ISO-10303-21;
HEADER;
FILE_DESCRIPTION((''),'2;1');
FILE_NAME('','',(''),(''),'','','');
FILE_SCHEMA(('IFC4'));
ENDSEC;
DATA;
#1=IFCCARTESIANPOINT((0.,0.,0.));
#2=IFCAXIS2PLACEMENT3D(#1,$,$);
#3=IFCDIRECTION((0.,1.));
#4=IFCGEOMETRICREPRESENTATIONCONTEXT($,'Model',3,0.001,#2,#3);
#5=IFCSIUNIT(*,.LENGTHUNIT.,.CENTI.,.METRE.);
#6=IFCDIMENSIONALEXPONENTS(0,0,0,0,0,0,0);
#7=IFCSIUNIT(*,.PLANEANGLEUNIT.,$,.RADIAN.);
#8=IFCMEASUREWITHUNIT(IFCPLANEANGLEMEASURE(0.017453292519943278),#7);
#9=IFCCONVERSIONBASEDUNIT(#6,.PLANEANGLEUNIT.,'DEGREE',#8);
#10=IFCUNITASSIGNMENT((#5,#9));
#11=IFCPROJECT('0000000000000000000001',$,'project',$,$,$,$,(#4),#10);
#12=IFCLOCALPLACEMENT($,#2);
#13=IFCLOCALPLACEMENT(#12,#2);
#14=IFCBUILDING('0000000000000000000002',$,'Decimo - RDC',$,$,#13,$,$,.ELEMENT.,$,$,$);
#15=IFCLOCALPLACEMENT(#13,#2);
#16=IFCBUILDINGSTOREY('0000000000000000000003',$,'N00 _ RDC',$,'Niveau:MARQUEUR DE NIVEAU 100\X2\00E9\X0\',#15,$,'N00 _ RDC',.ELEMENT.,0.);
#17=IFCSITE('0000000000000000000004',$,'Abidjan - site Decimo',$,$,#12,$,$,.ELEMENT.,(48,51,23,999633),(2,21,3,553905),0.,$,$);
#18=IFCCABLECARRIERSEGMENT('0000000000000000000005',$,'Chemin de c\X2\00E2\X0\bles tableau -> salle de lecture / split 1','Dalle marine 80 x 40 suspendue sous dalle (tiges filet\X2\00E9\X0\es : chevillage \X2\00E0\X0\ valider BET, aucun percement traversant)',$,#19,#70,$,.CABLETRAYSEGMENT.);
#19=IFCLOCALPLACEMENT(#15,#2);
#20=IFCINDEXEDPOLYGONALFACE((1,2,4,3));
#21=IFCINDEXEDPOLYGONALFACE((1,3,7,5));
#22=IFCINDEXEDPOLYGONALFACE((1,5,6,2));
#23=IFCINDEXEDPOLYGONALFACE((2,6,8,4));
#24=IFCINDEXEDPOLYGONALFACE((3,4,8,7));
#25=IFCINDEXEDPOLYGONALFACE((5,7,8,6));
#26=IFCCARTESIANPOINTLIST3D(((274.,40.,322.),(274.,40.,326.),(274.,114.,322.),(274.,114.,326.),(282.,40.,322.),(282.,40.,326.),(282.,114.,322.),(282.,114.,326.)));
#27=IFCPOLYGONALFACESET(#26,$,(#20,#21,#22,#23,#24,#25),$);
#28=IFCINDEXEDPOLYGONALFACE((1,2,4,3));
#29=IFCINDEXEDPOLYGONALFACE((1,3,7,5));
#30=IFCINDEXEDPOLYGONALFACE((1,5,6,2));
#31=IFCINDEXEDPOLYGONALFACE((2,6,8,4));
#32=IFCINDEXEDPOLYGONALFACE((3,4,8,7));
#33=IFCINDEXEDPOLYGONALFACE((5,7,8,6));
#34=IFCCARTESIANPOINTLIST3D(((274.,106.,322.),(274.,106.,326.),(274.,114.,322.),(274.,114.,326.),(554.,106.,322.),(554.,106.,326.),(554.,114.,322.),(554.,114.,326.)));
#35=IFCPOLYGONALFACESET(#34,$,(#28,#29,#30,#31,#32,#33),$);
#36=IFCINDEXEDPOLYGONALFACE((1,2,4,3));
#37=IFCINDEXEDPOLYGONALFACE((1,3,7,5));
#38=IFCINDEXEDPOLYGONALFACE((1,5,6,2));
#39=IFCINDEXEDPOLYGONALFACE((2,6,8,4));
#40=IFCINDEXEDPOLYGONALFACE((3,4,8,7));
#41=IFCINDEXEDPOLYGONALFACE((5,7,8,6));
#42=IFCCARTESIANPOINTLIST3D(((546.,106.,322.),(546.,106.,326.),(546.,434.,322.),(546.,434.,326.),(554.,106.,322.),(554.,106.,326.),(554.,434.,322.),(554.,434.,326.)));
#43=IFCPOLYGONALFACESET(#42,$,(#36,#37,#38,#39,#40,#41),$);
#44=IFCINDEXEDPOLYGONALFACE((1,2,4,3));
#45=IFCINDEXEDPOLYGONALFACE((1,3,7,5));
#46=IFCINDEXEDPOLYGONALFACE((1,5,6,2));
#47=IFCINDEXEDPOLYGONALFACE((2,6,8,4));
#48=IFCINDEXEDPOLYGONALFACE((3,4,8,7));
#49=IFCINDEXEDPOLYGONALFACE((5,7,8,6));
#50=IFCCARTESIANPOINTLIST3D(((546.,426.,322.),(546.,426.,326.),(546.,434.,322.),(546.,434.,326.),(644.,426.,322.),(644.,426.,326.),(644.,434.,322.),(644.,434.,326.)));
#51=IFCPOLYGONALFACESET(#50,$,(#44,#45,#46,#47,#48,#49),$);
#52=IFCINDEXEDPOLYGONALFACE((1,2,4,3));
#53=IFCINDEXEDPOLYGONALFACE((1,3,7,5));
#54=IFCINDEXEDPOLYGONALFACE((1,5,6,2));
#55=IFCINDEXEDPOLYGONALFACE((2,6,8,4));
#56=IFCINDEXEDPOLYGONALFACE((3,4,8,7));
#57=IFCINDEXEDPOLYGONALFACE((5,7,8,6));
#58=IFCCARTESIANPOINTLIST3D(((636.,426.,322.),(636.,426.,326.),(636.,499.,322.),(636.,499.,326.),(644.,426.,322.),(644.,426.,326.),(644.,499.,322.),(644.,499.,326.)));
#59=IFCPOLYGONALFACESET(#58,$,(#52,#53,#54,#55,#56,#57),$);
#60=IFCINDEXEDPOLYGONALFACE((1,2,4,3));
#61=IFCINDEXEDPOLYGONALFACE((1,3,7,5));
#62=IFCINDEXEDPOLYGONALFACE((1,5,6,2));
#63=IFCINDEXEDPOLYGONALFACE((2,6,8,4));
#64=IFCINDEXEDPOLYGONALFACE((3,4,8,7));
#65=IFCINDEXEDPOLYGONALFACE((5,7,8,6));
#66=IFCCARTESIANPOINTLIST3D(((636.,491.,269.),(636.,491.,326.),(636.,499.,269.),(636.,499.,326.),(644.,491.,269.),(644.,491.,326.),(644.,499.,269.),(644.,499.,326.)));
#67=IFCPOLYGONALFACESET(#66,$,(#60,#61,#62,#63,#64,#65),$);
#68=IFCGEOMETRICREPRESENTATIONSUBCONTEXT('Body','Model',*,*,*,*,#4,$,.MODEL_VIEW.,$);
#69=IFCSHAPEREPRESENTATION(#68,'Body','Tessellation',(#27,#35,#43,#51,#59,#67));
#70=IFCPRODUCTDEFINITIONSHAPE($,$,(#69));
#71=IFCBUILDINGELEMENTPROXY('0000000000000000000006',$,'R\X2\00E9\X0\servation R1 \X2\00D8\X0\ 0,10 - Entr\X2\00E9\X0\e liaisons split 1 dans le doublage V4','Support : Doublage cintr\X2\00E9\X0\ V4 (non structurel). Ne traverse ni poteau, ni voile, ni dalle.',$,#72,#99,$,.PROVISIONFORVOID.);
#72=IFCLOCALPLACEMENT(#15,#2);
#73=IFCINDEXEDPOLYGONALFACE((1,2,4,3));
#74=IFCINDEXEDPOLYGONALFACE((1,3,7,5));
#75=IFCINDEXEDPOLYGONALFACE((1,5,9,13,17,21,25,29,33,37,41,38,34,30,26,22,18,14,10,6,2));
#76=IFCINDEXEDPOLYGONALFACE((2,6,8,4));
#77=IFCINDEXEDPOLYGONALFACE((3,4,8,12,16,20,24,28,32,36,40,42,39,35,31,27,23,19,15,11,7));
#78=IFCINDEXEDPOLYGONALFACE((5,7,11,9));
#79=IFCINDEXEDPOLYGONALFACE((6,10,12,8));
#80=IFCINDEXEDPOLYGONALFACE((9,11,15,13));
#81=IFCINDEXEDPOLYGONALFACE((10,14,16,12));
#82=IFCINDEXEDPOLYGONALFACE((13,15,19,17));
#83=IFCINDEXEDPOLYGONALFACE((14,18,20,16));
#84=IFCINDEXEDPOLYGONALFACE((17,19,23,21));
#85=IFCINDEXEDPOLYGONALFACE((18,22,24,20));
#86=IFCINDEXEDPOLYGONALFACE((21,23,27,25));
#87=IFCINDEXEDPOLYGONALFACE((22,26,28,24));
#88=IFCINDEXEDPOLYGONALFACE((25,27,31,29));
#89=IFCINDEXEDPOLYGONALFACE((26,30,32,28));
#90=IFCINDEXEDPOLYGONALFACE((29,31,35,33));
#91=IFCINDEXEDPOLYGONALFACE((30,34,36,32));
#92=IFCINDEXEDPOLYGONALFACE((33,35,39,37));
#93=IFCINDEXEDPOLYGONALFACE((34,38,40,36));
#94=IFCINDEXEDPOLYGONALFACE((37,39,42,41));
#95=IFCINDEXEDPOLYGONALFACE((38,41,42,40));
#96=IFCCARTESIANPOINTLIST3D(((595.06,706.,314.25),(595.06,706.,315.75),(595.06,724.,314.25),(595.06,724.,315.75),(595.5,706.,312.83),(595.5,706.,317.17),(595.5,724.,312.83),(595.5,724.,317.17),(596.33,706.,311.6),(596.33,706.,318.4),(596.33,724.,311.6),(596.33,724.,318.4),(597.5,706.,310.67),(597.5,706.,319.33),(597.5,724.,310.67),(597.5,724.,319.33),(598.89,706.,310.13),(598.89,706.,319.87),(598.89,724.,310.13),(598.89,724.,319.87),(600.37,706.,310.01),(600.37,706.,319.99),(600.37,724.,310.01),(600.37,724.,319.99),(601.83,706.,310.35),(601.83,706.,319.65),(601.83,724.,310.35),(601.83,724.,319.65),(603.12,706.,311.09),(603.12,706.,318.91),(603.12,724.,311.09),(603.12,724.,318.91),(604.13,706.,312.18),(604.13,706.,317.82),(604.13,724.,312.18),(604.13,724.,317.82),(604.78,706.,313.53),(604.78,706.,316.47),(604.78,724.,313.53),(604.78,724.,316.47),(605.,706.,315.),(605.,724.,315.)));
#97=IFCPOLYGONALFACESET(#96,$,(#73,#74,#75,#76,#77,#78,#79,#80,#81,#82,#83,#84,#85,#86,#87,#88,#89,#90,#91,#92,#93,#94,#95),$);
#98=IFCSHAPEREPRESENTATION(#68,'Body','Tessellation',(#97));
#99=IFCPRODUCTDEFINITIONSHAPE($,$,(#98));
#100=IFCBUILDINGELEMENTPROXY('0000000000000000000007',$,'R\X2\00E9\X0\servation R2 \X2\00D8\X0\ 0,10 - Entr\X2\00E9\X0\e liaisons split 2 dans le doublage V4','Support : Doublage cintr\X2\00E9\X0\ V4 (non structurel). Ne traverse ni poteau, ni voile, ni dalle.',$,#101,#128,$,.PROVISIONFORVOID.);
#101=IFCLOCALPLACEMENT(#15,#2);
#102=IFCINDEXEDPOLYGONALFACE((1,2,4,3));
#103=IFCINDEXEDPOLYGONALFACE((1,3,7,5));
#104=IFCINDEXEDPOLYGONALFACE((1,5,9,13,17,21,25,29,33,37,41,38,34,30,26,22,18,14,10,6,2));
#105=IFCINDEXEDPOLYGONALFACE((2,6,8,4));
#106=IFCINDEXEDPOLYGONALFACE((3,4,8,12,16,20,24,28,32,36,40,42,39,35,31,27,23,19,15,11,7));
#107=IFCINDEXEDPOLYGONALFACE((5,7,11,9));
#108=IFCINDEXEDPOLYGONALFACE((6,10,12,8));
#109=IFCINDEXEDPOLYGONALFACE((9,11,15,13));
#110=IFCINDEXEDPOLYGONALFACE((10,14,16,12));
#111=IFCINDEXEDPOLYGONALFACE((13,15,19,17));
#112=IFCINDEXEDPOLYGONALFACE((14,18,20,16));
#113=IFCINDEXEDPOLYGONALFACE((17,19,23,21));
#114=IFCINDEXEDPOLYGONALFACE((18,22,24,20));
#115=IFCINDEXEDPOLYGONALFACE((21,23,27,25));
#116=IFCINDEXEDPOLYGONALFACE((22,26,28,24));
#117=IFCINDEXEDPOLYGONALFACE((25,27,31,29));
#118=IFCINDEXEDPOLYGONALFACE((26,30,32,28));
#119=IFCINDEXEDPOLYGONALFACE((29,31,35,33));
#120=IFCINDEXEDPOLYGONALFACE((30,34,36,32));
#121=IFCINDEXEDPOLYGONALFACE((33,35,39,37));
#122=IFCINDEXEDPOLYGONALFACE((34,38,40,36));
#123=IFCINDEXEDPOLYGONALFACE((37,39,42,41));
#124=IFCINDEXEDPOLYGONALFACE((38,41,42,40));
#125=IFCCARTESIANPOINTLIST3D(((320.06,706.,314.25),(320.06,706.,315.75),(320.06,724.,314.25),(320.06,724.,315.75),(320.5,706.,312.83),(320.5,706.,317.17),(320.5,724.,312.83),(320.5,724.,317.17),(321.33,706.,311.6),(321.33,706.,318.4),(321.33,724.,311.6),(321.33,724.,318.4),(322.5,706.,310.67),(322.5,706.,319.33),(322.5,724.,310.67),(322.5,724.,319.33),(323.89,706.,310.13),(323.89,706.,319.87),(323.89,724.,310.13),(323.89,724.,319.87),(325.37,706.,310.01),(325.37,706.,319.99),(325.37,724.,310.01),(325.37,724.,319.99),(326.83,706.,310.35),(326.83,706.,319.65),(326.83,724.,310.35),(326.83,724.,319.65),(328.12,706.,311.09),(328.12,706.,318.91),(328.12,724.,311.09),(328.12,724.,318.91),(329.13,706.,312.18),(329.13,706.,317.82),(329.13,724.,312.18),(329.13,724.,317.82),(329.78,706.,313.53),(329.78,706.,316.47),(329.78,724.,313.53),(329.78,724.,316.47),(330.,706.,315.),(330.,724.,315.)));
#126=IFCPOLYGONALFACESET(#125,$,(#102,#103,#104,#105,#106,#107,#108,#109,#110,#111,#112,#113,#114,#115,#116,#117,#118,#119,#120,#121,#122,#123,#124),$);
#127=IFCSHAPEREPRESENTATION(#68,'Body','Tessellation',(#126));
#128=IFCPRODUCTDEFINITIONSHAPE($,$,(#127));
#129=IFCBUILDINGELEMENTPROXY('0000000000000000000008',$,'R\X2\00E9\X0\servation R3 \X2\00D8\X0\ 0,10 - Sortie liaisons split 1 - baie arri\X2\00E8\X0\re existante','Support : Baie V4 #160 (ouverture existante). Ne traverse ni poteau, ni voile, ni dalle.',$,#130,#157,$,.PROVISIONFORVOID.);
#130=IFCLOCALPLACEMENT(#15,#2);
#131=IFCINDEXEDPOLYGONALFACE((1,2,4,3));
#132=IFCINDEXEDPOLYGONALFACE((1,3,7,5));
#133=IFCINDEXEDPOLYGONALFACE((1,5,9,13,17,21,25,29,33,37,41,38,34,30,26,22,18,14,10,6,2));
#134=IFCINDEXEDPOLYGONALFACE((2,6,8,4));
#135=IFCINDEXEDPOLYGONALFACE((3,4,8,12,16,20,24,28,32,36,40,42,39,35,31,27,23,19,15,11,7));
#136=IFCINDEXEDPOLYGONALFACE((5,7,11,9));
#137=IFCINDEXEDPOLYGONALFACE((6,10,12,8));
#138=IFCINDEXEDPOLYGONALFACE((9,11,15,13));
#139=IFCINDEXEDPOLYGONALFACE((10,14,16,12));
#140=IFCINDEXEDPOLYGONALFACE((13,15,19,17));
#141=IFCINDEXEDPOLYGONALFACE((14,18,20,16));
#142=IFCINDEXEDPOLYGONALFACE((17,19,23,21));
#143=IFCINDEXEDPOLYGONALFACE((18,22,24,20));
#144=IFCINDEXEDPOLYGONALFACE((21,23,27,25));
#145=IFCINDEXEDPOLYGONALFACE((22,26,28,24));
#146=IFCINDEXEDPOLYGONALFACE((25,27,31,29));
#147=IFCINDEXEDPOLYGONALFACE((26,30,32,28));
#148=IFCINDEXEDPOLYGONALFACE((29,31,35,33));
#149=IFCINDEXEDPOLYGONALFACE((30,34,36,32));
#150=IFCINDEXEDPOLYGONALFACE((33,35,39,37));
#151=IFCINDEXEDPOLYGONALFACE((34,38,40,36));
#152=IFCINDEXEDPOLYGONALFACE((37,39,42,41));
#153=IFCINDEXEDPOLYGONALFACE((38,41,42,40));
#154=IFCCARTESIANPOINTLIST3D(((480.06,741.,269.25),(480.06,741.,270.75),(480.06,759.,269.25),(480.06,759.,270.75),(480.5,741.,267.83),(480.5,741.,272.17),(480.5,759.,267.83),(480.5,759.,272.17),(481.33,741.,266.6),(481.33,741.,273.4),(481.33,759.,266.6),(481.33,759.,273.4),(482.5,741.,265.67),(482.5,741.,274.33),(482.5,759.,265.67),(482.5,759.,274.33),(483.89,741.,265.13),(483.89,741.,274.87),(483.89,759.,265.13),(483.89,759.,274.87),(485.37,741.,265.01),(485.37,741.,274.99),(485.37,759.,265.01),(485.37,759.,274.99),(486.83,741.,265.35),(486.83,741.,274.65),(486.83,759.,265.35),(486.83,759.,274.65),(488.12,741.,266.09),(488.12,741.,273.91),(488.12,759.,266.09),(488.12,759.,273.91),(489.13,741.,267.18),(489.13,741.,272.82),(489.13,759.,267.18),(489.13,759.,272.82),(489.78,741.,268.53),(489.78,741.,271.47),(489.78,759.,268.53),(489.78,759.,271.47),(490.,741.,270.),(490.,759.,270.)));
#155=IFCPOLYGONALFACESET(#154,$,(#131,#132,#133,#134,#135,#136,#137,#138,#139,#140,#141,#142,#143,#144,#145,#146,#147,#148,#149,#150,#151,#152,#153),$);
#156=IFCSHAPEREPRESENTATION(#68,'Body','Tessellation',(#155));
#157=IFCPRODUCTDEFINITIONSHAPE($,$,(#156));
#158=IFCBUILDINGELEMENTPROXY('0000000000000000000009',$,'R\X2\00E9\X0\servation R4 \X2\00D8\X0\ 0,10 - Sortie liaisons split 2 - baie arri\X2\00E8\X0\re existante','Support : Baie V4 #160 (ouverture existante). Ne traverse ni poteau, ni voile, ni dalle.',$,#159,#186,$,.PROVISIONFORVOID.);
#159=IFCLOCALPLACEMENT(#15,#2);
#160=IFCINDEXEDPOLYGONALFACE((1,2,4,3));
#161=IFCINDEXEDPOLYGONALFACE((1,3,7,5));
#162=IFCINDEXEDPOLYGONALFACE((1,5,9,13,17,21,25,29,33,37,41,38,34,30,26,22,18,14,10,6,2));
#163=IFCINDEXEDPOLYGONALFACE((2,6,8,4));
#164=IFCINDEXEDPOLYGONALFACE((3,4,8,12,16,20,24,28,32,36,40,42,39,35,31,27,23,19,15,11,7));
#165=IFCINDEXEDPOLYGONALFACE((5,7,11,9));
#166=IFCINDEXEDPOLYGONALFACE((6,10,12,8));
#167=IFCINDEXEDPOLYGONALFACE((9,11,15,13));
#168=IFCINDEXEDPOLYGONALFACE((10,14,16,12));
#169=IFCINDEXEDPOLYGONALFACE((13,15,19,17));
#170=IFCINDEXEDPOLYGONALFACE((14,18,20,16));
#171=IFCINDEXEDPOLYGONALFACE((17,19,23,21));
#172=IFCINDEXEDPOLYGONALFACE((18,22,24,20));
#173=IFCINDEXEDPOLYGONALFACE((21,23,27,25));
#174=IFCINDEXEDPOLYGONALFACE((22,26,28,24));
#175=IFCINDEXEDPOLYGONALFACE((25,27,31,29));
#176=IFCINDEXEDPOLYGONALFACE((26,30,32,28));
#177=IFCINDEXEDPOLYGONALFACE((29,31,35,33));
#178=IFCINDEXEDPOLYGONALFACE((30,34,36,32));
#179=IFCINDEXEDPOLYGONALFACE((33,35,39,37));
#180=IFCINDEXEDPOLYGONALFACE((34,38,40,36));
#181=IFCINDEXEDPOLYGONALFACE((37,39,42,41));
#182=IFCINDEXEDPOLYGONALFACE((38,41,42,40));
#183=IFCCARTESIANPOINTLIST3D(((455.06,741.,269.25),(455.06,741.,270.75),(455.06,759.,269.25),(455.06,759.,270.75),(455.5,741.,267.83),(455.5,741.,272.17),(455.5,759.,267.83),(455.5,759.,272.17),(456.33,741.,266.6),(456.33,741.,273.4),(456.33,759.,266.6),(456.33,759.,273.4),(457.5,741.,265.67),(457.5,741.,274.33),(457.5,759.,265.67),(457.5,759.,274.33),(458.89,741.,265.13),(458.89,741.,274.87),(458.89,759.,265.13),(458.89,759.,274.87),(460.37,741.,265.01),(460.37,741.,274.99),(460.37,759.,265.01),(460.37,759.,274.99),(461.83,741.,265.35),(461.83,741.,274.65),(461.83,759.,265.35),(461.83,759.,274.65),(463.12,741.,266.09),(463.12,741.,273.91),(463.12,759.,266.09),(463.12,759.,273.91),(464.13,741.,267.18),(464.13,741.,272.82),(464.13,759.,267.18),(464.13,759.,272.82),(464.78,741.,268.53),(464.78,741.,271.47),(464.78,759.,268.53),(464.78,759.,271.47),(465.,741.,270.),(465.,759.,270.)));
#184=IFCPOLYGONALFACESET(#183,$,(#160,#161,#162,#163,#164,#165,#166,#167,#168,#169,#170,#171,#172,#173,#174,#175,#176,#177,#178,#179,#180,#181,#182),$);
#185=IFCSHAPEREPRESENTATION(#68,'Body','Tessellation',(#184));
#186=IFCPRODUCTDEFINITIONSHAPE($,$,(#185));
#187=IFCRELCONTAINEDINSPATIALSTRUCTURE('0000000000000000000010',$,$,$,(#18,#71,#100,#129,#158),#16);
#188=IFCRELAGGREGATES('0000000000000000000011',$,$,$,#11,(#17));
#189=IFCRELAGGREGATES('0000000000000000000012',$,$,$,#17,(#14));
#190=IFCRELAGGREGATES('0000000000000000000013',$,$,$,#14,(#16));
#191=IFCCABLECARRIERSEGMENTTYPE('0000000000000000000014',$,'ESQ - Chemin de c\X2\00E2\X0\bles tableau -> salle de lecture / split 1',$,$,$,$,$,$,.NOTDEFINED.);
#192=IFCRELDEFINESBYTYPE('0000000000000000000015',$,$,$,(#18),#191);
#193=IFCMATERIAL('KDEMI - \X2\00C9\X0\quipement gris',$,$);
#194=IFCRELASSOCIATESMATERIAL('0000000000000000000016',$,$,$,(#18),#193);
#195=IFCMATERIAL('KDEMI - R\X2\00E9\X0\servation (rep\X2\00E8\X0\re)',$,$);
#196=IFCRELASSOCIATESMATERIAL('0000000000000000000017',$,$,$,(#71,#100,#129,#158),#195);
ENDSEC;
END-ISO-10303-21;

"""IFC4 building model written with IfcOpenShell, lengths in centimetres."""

from ifc_helpers import new_model, entity, si_unit, converted_unit, direction, frame, frame_2d, origin, origin_with_axes, origin_2d, place, context, subcontext, project, spatial, rectangle, circle, extrude, material, type_object, element, save


model = new_model("IFC4")

# Units and contexts
model_context = context("Model", 3, precision=0.001, world=origin(), true_north=direction((0.0, 1.0)))
body_context = subcontext(model_context, "Body", "Model", "MODEL_VIEW")
ifc_project = project(units=[si_unit("LENGTHUNIT", "METRE", prefix="CENTI"), converted_unit("PLANEANGLEUNIT", "DEGREE", entity("IfcPlaneAngleMeasure", 0.017453292519943278), si_unit("PLANEANGLEUNIT", "RADIAN"), dimensions=[0, 0, 0, 0, 0, 0, 0])], contexts=[model_context])

# Site, building, storey
site_placement = place(None, origin())
site = spatial("IfcSite", under=ifc_project, at=site_placement, Name="Abidjan - site Decimo", CompositionType="ELEMENT", RefLatitude=(48, 51, 23, 999633), RefLongitude=(2, 21, 3, 553905), RefElevation=0.0)
building_placement = place(site_placement, origin())
building = spatial("IfcBuilding", under=site, at=building_placement, Name="Decimo - RDC", CompositionType="ELEMENT")
storey_placement = place(building_placement, origin())
storey = spatial("IfcBuildingStorey", under=building, at=storey_placement, Name="N00 _ RDC", ObjectType="Niveau:MARQUEUR DE NIVEAU 100é", LongName="N00 _ RDC", CompositionType="ELEMENT", Elevation=0.0)

# Cable carrier segment
ifc_material_1 = material(Name="KDEMI - Équipement gris")
cable_carrier_segment_type_1 = type_object("IfcCableCarrierSegmentType", Name="ESQ - Chemin de câbles tableau -> salle de lecture / split 1", PredefinedType="NOTDEFINED")
cable_carrier_segment_1_placement = place(storey_placement, origin_with_axes())
element("IfcCableCarrierSegment", 1, at=cable_carrier_segment_1_placement, inside=storey, type_object=cable_carrier_segment_type_1, material=ifc_material_1, Name="Chemin de câbles tableau -> salle de lecture / split 1", Description="Dalle marine 80 x 40 suspendue sous dalle (tiges filetées : chevillage à valider BET, aucun percement traversant)", PredefinedType="CABLETRAYSEGMENT", context=body_context, shape_type="SweptSolid", body=[
    extrude(rectangle(XDim=8.0, YDim=74.0, at=frame_2d((278.0, 77.0))), frame((0.0, 0.0, 322.0)), (0.0, 0.0, 1.0), 4.0),
    extrude(rectangle(XDim=280.0, YDim=8.0, at=frame_2d((414.0, 110.0))), frame((0.0, 0.0, 322.0)), (0.0, 0.0, 1.0), 4.0),
    extrude(rectangle(XDim=8.0, YDim=328.0, at=frame_2d((550.0, 270.0))), frame((0.0, 0.0, 322.0)), (0.0, 0.0, 1.0), 4.0),
    extrude(rectangle(XDim=98.0, YDim=8.0, at=frame_2d((595.0, 430.0))), frame((0.0, 0.0, 322.0)), (0.0, 0.0, 1.0), 4.0),
    extrude(rectangle(XDim=8.0, YDim=73.0, at=frame_2d((640.0, 462.5))), frame((0.0, 0.0, 322.0)), (0.0, 0.0, 1.0), 4.0),
    extrude(rectangle(XDim=8.0, YDim=8.0, at=frame_2d((640.0, 495.0))), frame((0.0, 0.0, 269.0)), (0.0, 0.0, 1.0), 57.0),
])

# Building element proxies
ifc_material_2 = material(Name="KDEMI - Réservation (repère)")
proxy_1_placement = place(storey_placement, origin_with_axes())
element("IfcBuildingElementProxy", 2, at=proxy_1_placement, inside=storey, material=ifc_material_2, Name="Réservation R1 Ø 0,10 - Entrée liaisons split 1 dans le doublage V4", Description="Support : Doublage cintré V4 (non structurel). Ne traverse ni poteau, ni voile, ni dalle.", PredefinedType="PROVISIONFORVOID", context=body_context, shape_type="SweptSolid", body=[
    extrude(circle(Radius=5.0, at=origin_2d()), frame((600.0, 706.0, 315.0), z_axis=(0.0, 1.0, 0.0), x_axis=(1.0, 0.0, 0.0)), (0.0, 0.0, 1.0), 18.0),
])
proxy_2_placement = place(storey_placement, origin_with_axes())
element("IfcBuildingElementProxy", 3, at=proxy_2_placement, inside=storey, material=ifc_material_2, Name="Réservation R2 Ø 0,10 - Entrée liaisons split 2 dans le doublage V4", Description="Support : Doublage cintré V4 (non structurel). Ne traverse ni poteau, ni voile, ni dalle.", PredefinedType="PROVISIONFORVOID", context=body_context, shape_type="SweptSolid", body=[
    extrude(circle(Radius=5.0, at=origin_2d()), frame((325.0, 706.0, 315.0), z_axis=(0.0, 1.0, 0.0), x_axis=(1.0, 0.0, 0.0)), (0.0, 0.0, 1.0), 18.0),
])
proxy_3_placement = place(storey_placement, origin_with_axes())
element("IfcBuildingElementProxy", 4, at=proxy_3_placement, inside=storey, material=ifc_material_2, Name="Réservation R3 Ø 0,10 - Sortie liaisons split 1 - baie arrière existante", Description="Support : Baie V4 #160 (ouverture existante). Ne traverse ni poteau, ni voile, ni dalle.", PredefinedType="PROVISIONFORVOID", context=body_context, shape_type="SweptSolid", body=[
    extrude(circle(Radius=5.0, at=origin_2d()), frame((485.0, 741.0, 270.0), z_axis=(0.0, 1.0, 0.0), x_axis=(1.0, 0.0, 0.0)), (0.0, 0.0, 1.0), 18.0),
])
proxy_4_placement = place(storey_placement, origin_with_axes())
element("IfcBuildingElementProxy", 5, at=proxy_4_placement, inside=storey, material=ifc_material_2, Name="Réservation R4 Ø 0,10 - Sortie liaisons split 2 - baie arrière existante", Description="Support : Baie V4 #160 (ouverture existante). Ne traverse ni poteau, ni voile, ni dalle.", PredefinedType="PROVISIONFORVOID", context=body_context, shape_type="SweptSolid", body=[
    extrude(circle(Radius=5.0, at=origin_2d()), frame((460.0, 741.0, 270.0), z_axis=(0.0, 1.0, 0.0), x_axis=(1.0, 0.0, 0.0)), (0.0, 0.0, 1.0), 18.0),
])

save(model, "model.ifc")
